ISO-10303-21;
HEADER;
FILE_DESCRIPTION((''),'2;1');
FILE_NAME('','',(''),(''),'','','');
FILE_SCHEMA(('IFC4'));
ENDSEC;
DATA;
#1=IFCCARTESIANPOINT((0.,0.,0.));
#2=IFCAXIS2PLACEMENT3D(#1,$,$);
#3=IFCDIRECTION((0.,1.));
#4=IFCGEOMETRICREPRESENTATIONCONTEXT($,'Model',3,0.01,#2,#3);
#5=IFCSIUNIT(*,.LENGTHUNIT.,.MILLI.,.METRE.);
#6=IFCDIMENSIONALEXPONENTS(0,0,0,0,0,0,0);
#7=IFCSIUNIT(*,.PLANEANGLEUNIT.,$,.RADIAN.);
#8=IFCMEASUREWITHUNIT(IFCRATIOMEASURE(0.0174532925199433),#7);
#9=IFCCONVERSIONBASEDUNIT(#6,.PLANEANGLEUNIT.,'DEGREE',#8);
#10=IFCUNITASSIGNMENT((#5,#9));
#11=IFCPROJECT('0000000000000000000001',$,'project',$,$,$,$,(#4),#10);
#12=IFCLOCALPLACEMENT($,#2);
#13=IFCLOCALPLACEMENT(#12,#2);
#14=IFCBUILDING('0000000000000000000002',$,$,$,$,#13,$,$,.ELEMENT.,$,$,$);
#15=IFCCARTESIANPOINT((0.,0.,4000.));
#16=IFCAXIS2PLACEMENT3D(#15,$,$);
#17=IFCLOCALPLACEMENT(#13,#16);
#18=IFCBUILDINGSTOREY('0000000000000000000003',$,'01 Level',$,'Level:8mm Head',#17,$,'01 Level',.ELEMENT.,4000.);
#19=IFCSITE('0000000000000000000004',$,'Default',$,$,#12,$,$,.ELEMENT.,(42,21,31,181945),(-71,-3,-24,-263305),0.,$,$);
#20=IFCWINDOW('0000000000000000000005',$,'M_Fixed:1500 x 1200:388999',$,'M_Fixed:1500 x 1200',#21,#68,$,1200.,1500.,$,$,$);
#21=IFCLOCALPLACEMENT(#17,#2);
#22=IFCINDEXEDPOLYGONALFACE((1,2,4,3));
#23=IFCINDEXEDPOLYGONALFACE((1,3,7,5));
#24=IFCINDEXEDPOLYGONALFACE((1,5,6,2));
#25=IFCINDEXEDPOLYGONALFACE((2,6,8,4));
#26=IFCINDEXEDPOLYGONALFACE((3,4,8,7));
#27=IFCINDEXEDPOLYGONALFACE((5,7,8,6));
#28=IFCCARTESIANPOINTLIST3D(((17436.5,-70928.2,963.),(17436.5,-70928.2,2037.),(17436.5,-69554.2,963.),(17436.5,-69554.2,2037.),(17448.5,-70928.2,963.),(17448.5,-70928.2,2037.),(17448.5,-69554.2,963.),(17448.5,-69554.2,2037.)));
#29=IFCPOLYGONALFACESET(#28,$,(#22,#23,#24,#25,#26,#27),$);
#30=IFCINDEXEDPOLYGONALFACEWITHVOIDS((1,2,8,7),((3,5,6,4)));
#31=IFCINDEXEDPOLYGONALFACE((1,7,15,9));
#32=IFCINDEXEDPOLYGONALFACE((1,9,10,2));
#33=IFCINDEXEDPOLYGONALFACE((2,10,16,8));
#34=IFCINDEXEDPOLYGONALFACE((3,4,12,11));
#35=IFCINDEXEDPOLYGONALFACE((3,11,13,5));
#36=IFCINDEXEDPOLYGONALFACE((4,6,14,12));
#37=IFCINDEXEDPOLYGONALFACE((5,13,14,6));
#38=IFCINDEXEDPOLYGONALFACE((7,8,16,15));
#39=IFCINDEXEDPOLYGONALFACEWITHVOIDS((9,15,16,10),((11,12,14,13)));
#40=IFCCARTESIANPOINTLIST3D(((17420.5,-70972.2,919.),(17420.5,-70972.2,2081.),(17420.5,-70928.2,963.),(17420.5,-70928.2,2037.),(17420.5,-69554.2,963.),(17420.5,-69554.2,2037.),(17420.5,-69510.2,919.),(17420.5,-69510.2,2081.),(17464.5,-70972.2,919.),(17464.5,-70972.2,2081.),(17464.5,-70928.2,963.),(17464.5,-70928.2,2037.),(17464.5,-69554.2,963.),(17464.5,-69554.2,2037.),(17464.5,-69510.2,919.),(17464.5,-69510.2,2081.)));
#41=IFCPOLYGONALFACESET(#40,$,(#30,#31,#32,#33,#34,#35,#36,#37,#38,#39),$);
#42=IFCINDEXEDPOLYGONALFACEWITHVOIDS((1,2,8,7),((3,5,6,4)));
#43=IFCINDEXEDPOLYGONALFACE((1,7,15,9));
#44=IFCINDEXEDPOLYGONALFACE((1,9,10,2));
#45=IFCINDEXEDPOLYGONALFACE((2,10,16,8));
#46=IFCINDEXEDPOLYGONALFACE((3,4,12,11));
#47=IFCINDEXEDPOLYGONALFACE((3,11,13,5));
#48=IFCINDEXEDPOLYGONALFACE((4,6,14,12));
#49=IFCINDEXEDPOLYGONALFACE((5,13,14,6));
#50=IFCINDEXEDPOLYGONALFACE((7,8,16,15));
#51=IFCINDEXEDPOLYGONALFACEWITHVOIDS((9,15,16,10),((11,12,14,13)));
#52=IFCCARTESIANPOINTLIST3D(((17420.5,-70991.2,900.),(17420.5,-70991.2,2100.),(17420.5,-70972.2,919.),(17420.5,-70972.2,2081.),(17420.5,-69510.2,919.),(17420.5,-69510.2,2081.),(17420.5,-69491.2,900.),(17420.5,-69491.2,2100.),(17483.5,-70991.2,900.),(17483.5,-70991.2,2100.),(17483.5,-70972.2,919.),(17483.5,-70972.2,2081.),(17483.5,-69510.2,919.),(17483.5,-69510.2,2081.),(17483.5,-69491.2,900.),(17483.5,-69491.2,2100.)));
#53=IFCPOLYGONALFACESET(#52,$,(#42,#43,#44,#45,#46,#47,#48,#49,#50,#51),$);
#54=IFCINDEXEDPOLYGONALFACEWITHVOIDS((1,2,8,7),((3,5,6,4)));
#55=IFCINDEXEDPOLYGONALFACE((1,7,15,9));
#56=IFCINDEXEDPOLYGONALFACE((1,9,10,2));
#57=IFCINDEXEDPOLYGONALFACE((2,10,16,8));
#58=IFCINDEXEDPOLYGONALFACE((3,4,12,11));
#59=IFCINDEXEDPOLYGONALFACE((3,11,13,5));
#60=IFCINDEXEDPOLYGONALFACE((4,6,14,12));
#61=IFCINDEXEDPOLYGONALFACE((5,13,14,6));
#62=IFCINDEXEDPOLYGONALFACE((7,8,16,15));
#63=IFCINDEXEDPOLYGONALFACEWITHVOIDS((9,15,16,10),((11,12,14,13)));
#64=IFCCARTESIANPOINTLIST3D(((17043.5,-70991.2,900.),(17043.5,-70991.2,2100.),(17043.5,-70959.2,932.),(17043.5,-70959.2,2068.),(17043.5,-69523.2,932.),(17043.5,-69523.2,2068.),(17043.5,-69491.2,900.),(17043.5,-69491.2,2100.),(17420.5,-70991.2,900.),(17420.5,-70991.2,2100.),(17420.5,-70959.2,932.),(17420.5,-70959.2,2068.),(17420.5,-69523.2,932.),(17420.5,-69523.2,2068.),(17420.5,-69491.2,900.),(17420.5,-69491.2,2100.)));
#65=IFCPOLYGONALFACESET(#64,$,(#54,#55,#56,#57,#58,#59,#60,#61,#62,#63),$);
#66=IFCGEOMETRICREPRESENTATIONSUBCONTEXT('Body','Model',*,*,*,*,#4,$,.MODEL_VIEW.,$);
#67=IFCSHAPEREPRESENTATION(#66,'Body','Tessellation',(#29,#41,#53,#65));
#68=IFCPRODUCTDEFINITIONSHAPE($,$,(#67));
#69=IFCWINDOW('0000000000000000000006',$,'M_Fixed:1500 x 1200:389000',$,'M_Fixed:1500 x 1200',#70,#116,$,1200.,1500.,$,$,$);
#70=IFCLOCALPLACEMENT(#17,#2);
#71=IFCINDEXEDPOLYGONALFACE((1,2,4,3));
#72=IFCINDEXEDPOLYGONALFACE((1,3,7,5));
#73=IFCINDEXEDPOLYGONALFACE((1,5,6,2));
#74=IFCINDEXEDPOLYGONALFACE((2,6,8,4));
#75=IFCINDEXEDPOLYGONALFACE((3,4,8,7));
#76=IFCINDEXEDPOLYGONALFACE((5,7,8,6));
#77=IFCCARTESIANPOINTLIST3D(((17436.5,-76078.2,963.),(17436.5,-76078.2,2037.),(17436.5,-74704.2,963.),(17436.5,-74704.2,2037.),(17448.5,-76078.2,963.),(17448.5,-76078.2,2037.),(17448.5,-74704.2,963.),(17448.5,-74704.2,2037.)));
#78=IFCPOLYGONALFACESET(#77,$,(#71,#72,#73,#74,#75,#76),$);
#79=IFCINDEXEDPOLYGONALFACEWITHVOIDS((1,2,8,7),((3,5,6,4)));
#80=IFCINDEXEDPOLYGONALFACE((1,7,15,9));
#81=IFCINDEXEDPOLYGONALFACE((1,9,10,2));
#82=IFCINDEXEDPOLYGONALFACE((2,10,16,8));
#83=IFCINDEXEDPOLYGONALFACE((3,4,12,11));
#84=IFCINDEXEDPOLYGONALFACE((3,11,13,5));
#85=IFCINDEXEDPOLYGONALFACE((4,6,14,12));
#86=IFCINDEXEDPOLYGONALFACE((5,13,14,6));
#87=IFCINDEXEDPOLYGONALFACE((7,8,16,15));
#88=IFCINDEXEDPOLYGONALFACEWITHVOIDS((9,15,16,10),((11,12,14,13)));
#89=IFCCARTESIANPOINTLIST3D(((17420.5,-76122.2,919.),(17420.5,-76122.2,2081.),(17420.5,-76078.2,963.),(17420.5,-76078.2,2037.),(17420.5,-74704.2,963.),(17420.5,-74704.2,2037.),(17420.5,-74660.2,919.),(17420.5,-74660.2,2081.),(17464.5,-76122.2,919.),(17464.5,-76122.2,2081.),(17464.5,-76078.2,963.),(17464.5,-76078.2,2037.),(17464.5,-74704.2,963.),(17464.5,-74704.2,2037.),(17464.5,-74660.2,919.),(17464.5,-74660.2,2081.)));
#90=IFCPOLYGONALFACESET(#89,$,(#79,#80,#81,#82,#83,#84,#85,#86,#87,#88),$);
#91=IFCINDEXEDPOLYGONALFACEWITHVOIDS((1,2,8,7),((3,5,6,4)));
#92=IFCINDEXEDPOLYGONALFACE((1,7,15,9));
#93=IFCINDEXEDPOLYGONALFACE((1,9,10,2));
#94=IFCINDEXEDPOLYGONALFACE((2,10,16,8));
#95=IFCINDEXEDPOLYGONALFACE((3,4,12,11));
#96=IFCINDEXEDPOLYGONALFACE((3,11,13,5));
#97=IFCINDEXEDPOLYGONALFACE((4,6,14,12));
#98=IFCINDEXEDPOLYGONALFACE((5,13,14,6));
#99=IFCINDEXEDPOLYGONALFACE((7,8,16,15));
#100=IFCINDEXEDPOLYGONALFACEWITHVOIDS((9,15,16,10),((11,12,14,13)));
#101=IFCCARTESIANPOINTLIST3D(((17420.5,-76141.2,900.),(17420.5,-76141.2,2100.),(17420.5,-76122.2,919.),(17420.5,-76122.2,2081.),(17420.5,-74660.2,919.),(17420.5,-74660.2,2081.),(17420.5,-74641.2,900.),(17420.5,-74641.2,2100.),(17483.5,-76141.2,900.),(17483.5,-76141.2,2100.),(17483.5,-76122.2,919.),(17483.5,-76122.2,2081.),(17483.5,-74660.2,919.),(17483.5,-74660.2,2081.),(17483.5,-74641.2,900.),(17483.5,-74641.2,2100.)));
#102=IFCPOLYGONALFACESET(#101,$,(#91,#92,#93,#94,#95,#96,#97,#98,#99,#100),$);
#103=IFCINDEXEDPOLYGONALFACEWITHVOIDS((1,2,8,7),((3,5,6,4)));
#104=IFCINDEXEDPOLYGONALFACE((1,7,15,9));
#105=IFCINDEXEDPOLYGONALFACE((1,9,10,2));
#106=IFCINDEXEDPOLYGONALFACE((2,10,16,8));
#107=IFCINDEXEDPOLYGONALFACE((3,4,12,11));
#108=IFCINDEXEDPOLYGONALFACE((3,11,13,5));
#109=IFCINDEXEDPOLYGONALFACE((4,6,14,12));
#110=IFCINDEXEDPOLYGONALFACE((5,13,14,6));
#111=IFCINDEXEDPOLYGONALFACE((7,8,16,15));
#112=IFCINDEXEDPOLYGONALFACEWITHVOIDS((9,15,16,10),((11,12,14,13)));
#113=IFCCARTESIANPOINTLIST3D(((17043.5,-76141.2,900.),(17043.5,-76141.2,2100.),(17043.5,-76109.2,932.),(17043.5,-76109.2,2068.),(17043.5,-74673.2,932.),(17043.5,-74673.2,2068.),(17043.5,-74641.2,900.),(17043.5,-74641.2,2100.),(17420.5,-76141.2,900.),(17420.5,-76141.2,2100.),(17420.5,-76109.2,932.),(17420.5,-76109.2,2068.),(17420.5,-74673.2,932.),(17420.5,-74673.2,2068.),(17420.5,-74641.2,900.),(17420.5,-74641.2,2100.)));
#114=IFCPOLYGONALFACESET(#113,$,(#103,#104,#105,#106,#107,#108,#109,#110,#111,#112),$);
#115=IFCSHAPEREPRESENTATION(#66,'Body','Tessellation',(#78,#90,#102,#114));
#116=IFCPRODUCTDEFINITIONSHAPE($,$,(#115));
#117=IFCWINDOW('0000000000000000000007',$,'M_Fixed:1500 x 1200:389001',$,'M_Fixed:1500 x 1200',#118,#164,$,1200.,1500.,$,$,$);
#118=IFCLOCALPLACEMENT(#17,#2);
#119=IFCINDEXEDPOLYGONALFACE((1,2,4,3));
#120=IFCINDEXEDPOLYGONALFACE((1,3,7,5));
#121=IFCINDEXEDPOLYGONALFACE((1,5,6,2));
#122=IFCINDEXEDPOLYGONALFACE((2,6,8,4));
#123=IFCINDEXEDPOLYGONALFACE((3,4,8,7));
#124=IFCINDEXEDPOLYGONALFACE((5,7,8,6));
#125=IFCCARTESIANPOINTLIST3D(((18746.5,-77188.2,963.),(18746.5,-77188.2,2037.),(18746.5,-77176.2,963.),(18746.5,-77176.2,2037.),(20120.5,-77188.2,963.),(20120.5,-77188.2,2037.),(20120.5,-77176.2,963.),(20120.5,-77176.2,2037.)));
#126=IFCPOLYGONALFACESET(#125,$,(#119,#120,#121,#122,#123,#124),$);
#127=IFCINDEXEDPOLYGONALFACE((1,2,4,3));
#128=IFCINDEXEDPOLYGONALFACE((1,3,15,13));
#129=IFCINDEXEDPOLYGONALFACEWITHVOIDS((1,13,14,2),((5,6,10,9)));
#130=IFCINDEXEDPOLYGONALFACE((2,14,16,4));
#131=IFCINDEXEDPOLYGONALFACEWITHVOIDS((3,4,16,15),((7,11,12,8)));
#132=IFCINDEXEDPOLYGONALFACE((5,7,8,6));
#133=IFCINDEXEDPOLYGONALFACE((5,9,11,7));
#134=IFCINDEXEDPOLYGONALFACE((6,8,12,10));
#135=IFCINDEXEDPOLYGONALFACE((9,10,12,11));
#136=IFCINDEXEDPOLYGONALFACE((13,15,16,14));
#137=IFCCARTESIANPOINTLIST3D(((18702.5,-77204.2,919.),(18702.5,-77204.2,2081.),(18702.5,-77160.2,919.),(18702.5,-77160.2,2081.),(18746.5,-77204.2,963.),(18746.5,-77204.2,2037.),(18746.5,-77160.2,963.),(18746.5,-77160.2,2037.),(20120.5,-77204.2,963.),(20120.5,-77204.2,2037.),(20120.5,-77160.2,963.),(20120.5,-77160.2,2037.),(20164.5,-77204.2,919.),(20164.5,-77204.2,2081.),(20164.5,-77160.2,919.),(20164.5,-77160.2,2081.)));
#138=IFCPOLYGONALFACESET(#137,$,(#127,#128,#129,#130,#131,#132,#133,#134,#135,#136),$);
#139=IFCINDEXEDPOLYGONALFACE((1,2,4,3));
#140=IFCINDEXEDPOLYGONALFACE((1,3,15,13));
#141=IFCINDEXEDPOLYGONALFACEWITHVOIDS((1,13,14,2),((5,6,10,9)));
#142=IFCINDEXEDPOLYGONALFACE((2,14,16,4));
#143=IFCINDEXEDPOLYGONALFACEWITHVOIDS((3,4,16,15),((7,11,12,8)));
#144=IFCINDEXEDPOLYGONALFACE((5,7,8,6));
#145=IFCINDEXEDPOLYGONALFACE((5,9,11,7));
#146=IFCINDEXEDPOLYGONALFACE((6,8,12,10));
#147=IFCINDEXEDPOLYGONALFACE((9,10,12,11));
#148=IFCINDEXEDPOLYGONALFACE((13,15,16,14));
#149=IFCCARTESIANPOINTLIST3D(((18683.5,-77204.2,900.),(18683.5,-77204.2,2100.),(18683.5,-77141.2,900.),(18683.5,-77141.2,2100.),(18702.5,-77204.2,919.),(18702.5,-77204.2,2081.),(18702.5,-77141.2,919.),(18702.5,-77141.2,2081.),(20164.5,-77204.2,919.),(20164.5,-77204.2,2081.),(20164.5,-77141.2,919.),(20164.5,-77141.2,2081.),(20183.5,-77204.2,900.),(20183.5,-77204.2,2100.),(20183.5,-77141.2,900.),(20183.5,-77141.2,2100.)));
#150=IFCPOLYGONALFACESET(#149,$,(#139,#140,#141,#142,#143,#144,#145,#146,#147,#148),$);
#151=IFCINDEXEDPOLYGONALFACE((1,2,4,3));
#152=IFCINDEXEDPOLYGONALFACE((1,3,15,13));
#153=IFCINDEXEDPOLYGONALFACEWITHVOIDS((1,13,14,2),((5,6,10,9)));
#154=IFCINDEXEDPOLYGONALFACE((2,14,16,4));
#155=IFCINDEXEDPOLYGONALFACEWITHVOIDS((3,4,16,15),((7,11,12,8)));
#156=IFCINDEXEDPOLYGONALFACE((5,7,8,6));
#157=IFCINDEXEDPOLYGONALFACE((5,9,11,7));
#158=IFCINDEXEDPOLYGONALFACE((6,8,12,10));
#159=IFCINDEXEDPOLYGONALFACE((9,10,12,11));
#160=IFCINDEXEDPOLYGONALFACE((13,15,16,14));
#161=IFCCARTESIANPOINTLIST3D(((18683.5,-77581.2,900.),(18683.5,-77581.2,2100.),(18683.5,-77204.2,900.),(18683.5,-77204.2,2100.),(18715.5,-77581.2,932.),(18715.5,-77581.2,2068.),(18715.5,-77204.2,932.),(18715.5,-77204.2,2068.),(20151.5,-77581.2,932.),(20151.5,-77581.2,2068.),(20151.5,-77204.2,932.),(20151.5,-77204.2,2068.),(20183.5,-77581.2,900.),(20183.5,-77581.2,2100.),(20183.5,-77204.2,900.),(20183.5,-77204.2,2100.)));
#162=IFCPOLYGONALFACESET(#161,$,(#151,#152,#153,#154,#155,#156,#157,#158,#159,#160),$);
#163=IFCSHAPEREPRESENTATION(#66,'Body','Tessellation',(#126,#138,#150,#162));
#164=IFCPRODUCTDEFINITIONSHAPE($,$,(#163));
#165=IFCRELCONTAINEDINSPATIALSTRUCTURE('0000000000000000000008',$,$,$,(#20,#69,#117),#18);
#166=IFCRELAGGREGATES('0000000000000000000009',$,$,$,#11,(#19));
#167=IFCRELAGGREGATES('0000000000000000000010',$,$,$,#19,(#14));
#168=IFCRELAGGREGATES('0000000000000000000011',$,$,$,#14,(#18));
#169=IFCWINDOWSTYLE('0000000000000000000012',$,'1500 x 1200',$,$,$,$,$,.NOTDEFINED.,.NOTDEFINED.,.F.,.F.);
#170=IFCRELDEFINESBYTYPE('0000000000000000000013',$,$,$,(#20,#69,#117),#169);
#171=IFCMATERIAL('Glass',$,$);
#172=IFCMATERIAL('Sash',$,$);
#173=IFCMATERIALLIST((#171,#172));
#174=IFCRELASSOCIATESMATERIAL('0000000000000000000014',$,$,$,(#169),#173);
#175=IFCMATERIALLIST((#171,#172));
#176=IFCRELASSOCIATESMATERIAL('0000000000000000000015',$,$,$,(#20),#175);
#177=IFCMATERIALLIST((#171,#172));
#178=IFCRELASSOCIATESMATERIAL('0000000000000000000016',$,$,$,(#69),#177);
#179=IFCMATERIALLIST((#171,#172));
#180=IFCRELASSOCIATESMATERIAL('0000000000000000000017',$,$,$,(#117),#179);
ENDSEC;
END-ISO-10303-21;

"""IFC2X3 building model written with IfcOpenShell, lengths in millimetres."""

from ifc_helpers import new_model, entity, si_unit, converted_unit, direction, frame, origin, origin_2d_with_axis, place, context, subcontext, project, spatial, polyline, rectangle, outline, extrude, source, transform, mapped, material, material_list, type_object, type_shapes, element, save


model = new_model("IFC2X3")

# Units and contexts
model_context = context("Model", 3, precision=0.01, world=origin(), true_north=direction((0.0, 1.0)))
body_context = subcontext(model_context, "Body", "Model", "MODEL_VIEW")
ifc_project = project(units=[si_unit("LENGTHUNIT", "METRE", prefix="MILLI"), converted_unit("PLANEANGLEUNIT", "DEGREE", entity("IfcRatioMeasure", 0.0174532925199433), si_unit("PLANEANGLEUNIT", "RADIAN"), dimensions=[0, 0, 0, 0, 0, 0, 0])], contexts=[model_context])

# Site, building, storey
site_placement = place(None, origin())
site = spatial("IfcSite", under=ifc_project, at=site_placement, Name="Default", CompositionType="ELEMENT", RefLatitude=(42, 21, 31, 181945), RefLongitude=(-71, -3, -24, -263305), RefElevation=0.0)
building_placement = place(site_placement, origin())
building = spatial("IfcBuilding", under=site, at=building_placement, CompositionType="ELEMENT")
storey_placement = place(building_placement, frame((0.0, 0.0, 4000.0)))
storey = spatial("IfcBuildingStorey", under=building, at=storey_placement, Name="01 Level", ObjectType="Level:8mm Head", LongName="01 Level", CompositionType="ELEMENT", Elevation=4000.0)

# Windows
ifc_material_1 = material(Name="Glass")
ifc_material_2 = material(Name="Sash")
ifc_material_list_1 = material_list([ifc_material_1, ifc_material_2])
ifc_material_list_2 = material_list([ifc_material_1, ifc_material_2])
window_style_1 = type_object("IfcWindowStyle", Name="1500 x 1200", ConstructionType="NOTDEFINED", OperationType="NOTDEFINED", ParameterTakesPrecedence=False, Sizeable=False, material=ifc_material_list_2)
shared_shape_1 = source(origin(), body_context, "Body", "SweptSolid", [
    extrude(rectangle(XDim=12.0, YDim=1374.0, at=origin_2d_with_axis()), frame((750.0, 399.0, 63.0), z_axis=(0.0, 0.0, 1.0), x_axis=(0.0, -1.0, 0.0)), (0.0, 0.0, 1.0), 1074.0),
    extrude(outline(polyline([(-731.0, -581.0), (731.0, -581.0), (731.0, 581.0), (-731.0, 581.0), (-731.0, -581.0)]), holes=[polyline([(-687.0, -537.0), (-687.0, 537.0), (687.0, 537.0), (687.0, -537.0), (-687.0, -537.0)])]), frame((750.0, 377.0, 600.0), z_axis=(0.0, 1.0, 0.0), x_axis=(1.0, 0.0, 0.0)), (0.0, 0.0, 1.0), 44.0),
    extrude(outline(polyline([(-750.0, -600.0), (750.0, -600.0), (750.0, 600.0), (-750.0, 600.0), (-750.0, -600.0)]), holes=[polyline([(-731.0, -581.0), (-731.0, 581.0), (731.0, 581.0), (731.0, -581.0), (-731.0, -581.0)])]), frame((750.0, 377.0, 600.0), z_axis=(0.0, 1.0, 0.0), x_axis=(1.0, 0.0, 0.0)), (0.0, 0.0, 1.0), 63.0),
    extrude(outline(polyline([(-750.0, -600.0), (750.0, -600.0), (750.0, 600.0), (-750.0, 600.0), (-750.0, -600.0)]), holes=[polyline([(-718.0, -568.0), (-718.0, 568.0), (718.0, 568.0), (718.0, -568.0), (-718.0, -568.0)])]), frame((750.0, 0.0, 600.0), z_axis=(0.0, 1.0, 0.0), x_axis=(1.0, 0.0, 0.0)), (0.0, 0.0, 1.0), 377.0),
])
type_shapes(window_style_1, [shared_shape_1])
window_1_placement = place(storey_placement, frame((17043.5, -69491.2, 900.0), z_axis=(0.0, 0.0, 1.0), x_axis=(0.0, -1.0, 0.0)))
element("IfcWindow", 1, at=window_1_placement, inside=storey, type_object=window_style_1, material=ifc_material_list_1, Name="M_Fixed:1500 x 1200:388999", ObjectType="M_Fixed:1500 x 1200", OverallHeight=1200.0, OverallWidth=1500.0, context=body_context, shape_type="MappedRepresentation", body=[
    mapped(shared_shape_1, transform((0.0, 0.0, 0.0), scale=1.0)),
])
ifc_material_list_3 = material_list([ifc_material_1, ifc_material_2])
window_2_placement = place(storey_placement, frame((17043.5, -74641.2, 900.0), z_axis=(0.0, 0.0, 1.0), x_axis=(0.0, -1.0, 0.0)))
element("IfcWindow", 2, at=window_2_placement, inside=storey, type_object=window_style_1, material=ifc_material_list_3, Name="M_Fixed:1500 x 1200:389000", ObjectType="M_Fixed:1500 x 1200", OverallHeight=1200.0, OverallWidth=1500.0, context=body_context, shape_type="MappedRepresentation", body=[
    mapped(shared_shape_1, transform((0.0, 0.0, 0.0), scale=1.0)),
])
ifc_material_list_4 = material_list([ifc_material_1, ifc_material_2])
window_3_placement = place(storey_placement, frame((18683.5, -77581.2, 900.0)))
element("IfcWindow", 3, at=window_3_placement, inside=storey, type_object=window_style_1, material=ifc_material_list_4, Name="M_Fixed:1500 x 1200:389001", ObjectType="M_Fixed:1500 x 1200", OverallHeight=1200.0, OverallWidth=1500.0, context=body_context, shape_type="MappedRepresentation", body=[
    mapped(shared_shape_1, transform((0.0, 0.0, 0.0), scale=1.0)),
])

save(model, "model.ifc")
